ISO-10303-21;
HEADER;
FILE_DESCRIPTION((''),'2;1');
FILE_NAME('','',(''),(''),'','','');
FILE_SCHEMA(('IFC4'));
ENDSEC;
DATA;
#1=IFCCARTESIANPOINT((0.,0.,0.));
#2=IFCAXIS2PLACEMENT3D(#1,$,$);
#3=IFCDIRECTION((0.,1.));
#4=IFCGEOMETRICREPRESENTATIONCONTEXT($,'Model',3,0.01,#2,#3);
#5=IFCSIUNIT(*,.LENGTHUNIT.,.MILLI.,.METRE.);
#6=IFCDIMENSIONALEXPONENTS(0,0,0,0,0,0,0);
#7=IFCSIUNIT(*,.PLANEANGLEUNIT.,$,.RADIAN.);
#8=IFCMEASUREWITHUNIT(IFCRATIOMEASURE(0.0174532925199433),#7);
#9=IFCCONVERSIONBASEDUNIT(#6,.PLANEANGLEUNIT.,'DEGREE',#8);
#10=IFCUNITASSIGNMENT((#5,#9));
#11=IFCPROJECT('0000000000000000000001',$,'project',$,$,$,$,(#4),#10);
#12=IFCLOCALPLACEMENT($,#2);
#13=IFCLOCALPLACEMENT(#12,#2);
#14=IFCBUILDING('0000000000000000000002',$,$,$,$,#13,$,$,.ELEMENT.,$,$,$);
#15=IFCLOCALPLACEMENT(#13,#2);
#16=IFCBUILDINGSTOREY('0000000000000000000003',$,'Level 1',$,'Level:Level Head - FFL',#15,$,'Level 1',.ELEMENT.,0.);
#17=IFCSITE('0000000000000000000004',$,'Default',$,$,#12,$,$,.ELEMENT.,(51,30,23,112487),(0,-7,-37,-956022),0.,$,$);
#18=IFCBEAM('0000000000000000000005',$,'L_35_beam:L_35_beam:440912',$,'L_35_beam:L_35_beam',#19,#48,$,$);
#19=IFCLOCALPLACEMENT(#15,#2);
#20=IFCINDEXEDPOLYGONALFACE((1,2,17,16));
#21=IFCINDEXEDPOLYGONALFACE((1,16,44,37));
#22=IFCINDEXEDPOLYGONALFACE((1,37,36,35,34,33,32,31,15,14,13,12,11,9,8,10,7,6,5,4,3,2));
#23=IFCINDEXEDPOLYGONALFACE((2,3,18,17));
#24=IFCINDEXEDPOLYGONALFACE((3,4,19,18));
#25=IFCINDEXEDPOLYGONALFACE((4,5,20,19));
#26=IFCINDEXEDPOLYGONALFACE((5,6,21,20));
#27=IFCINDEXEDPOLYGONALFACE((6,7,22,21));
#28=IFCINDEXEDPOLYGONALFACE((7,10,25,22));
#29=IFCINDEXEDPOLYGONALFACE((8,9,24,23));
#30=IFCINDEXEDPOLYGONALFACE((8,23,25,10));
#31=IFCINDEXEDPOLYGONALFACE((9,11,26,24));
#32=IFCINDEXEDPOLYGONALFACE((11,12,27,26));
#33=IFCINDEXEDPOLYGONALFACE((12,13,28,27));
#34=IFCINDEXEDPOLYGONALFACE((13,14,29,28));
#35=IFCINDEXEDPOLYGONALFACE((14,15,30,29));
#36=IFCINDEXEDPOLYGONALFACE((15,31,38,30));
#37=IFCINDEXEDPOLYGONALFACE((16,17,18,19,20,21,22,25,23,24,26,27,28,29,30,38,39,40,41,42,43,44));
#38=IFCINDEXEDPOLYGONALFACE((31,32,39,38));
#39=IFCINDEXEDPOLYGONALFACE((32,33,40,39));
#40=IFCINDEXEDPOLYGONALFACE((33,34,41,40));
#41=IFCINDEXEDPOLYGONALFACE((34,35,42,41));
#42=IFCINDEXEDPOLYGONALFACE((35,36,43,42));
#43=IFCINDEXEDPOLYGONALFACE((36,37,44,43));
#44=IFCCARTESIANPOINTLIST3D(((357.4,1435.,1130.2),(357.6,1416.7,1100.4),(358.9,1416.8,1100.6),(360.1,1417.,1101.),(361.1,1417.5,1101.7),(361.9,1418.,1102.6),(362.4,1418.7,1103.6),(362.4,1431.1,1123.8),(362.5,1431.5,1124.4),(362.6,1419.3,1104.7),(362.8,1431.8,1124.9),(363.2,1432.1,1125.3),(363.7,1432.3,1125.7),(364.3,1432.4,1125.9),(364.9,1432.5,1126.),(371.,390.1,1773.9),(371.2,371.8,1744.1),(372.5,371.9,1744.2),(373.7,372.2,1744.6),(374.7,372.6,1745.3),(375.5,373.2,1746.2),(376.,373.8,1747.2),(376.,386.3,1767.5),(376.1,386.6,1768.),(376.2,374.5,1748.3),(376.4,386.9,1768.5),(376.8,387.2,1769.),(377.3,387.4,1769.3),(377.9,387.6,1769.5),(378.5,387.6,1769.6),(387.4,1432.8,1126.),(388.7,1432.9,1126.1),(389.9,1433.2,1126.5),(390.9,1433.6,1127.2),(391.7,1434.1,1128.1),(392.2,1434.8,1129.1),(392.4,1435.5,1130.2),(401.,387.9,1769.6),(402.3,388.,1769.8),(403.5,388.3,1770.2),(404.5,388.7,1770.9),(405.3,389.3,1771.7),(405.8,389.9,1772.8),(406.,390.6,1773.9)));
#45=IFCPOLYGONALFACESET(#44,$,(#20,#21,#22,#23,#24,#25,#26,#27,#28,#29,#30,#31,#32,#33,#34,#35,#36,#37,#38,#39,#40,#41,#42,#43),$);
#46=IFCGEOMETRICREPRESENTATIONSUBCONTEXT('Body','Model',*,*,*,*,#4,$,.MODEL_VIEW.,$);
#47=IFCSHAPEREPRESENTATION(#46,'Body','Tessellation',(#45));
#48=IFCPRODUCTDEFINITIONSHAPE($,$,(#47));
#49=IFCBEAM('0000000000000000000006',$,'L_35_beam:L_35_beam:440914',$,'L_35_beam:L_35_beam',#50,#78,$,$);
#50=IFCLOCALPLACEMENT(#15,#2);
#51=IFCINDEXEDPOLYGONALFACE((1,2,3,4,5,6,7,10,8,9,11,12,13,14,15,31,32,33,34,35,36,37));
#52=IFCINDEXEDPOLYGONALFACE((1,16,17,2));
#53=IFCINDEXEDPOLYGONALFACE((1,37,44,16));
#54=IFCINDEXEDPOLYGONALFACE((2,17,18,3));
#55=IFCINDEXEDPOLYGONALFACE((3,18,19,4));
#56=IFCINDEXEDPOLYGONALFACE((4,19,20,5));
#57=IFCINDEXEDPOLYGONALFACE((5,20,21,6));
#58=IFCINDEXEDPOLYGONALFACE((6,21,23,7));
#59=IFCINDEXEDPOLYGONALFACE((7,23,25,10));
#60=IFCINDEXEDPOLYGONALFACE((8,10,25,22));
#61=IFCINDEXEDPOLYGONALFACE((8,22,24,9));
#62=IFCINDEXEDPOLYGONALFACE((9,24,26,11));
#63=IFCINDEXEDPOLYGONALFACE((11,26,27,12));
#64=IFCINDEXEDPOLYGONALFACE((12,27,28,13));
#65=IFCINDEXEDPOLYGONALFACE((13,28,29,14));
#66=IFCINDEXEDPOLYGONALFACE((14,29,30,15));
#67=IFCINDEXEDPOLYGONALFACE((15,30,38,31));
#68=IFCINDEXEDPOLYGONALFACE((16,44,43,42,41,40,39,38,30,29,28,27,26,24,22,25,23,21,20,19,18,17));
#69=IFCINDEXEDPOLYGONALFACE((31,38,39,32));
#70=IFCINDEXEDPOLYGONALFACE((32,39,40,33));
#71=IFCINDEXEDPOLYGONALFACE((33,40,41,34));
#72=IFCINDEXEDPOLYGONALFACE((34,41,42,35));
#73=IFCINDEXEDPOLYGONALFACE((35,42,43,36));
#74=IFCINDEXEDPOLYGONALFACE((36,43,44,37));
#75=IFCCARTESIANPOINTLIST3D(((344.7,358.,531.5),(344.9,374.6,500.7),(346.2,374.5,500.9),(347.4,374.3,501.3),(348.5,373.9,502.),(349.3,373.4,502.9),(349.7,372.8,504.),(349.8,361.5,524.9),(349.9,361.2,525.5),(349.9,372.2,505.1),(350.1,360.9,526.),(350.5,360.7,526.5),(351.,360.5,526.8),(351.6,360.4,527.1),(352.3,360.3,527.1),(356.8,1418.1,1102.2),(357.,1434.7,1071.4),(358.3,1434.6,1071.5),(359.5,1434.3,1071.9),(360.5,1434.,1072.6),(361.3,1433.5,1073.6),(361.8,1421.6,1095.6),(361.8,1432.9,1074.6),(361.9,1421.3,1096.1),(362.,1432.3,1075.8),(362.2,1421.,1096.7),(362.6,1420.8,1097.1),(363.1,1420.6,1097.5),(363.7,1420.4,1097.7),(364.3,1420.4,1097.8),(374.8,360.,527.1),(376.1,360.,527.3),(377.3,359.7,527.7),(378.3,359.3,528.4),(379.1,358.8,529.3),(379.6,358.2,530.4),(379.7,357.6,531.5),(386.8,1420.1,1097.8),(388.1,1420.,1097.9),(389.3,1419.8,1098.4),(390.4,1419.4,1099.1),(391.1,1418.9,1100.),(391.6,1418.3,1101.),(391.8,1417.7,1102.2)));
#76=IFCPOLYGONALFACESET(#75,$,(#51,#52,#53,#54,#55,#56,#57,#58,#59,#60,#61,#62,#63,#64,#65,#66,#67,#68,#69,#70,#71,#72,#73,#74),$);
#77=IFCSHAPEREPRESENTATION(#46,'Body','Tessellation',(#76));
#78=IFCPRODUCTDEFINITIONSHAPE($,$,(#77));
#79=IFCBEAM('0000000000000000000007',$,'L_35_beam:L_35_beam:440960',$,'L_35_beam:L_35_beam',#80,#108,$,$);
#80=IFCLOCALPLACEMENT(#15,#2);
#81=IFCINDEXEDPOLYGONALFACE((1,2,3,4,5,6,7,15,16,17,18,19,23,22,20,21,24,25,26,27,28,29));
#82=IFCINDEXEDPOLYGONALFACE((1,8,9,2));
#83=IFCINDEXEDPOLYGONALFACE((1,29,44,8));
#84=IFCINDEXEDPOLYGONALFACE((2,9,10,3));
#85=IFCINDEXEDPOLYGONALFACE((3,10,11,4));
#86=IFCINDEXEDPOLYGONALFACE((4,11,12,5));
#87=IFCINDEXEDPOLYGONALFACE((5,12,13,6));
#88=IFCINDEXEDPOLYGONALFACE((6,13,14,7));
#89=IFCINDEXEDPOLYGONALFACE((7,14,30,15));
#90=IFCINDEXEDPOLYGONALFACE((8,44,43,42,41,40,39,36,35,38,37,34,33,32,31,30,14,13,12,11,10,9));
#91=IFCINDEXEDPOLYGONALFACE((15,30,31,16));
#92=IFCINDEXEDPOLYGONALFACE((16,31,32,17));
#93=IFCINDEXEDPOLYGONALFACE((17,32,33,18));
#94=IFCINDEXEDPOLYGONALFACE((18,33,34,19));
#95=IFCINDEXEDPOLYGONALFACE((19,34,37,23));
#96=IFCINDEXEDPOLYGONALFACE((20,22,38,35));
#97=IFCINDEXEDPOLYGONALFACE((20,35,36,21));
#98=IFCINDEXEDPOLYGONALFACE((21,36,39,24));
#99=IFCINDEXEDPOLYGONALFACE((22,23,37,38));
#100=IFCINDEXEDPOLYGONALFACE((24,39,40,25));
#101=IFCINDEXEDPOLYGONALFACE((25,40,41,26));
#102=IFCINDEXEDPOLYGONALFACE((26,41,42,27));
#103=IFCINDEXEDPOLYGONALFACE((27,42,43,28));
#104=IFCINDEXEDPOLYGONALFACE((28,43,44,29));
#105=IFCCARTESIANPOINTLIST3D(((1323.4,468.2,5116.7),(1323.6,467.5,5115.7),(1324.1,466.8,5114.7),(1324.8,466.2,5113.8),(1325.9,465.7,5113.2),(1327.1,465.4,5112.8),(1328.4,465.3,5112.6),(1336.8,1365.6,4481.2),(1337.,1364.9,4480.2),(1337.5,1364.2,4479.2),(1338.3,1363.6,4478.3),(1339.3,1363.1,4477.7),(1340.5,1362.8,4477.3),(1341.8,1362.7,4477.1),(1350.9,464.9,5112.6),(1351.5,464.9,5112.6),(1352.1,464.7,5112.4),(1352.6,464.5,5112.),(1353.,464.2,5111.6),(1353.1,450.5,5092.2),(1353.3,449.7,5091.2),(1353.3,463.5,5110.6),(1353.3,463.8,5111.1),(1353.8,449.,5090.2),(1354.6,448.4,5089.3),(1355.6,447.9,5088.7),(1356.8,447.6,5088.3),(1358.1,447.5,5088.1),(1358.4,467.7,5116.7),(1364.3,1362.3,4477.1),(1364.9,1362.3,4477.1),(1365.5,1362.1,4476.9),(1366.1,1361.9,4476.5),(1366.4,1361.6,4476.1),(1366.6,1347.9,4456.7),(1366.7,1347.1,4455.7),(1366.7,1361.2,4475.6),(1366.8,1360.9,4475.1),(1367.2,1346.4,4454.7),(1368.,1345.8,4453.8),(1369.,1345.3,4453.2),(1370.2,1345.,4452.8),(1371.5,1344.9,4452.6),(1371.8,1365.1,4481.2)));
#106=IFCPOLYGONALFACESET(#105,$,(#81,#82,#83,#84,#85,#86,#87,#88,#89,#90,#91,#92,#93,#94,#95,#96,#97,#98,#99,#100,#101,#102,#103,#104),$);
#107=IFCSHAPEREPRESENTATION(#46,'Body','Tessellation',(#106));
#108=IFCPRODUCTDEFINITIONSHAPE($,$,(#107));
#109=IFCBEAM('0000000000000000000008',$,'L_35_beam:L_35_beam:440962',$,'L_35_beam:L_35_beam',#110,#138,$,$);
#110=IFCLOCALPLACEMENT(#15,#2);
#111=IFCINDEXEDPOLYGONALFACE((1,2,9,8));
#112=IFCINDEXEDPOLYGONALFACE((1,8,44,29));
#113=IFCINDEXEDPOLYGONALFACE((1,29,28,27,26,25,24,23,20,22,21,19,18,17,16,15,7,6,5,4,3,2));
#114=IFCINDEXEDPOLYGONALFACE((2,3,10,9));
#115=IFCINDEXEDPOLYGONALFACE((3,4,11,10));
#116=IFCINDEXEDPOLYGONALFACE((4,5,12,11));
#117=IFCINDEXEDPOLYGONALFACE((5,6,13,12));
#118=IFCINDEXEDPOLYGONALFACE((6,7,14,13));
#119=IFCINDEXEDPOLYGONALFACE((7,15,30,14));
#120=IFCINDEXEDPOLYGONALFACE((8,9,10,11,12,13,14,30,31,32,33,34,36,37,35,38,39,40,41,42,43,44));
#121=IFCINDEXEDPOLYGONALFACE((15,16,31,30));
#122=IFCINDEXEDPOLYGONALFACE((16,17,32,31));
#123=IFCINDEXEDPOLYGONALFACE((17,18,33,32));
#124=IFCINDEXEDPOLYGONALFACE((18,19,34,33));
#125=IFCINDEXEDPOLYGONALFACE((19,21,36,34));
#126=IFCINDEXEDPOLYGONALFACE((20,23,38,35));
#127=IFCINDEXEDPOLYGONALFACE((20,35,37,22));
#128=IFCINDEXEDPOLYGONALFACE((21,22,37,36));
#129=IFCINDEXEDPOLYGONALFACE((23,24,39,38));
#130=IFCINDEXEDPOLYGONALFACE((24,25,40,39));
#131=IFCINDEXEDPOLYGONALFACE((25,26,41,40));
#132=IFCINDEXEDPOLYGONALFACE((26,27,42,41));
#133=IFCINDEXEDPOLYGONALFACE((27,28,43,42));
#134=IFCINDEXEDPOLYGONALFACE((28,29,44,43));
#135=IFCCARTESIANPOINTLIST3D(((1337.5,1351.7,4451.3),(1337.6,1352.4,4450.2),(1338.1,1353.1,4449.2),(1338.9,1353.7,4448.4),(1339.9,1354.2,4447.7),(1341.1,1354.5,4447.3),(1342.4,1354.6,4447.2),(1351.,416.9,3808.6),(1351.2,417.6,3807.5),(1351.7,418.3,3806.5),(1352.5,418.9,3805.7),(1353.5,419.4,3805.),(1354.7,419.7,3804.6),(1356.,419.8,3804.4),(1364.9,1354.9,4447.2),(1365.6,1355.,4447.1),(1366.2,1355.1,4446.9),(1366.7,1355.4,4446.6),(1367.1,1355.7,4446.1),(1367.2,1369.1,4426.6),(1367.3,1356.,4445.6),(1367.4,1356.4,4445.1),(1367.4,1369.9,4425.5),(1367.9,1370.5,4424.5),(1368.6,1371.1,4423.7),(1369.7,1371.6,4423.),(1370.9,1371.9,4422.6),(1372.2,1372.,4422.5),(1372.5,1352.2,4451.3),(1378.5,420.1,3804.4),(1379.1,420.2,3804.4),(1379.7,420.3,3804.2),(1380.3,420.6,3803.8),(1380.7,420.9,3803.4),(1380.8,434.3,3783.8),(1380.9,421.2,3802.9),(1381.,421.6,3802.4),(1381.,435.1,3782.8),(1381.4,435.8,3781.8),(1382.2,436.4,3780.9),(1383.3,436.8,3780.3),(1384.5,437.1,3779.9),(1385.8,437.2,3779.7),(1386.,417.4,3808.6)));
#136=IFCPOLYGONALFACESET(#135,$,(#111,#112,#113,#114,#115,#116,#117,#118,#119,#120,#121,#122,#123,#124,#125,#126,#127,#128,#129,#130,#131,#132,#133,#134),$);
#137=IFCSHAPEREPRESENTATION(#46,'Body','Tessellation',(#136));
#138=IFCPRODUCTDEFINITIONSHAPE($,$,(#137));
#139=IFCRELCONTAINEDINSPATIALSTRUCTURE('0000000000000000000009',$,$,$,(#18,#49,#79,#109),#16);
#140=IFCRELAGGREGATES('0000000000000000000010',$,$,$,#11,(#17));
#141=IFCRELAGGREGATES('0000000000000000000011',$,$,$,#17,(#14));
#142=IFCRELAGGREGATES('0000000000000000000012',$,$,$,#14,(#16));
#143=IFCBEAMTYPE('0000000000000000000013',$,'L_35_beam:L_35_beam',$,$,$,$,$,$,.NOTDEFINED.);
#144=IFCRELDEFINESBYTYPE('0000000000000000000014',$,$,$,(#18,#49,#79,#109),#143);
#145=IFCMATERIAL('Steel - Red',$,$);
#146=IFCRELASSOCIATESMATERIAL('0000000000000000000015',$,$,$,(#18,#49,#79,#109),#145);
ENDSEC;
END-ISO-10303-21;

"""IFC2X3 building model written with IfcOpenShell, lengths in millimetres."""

from ifc_helpers import new_model, entity, si_unit, converted_unit, direction, frame, frame_2d, origin, place, context, subcontext, project, spatial, polyline, circle_curve, parameter, trimmed, segment, composite_curve, outline, extrude, material, type_object, element, save


model = new_model("IFC2X3")

# Units and contexts
model_context = context("Model", 3, precision=0.01, world=origin(), true_north=direction((0.0, 1.0)))
body_context = subcontext(model_context, "Body", "Model", "MODEL_VIEW")
ifc_project = project(units=[si_unit("LENGTHUNIT", "METRE", prefix="MILLI"), converted_unit("PLANEANGLEUNIT", "DEGREE", entity("IfcRatioMeasure", 0.0174532925199433), si_unit("PLANEANGLEUNIT", "RADIAN"), dimensions=[0, 0, 0, 0, 0, 0, 0])], contexts=[model_context])

# Site, building, storey
site_placement = place(None, origin())
site = spatial("IfcSite", under=ifc_project, at=site_placement, Name="Default", CompositionType="ELEMENT", RefLatitude=(51, 30, 23, 112487), RefLongitude=(0, -7, -37, -956022), RefElevation=0.0)
building_placement = place(site_placement, origin())
building = spatial("IfcBuilding", under=site, at=building_placement, CompositionType="ELEMENT")
storey_placement = place(building_placement, origin())
storey = spatial("IfcBuildingStorey", under=building, at=storey_placement, Name="Level 1", ObjectType="Level:Level Head - FFL", LongName="Level 1", CompositionType="ELEMENT", Elevation=0.0)

# Beams
ifc_material_1 = material(Name="Steel - Red")
beam_type = type_object("IfcBeamType", Name="L_35_beam:L_35_beam", PredefinedType="NOTDEFINED")
beam_1_placement = place(storey_placement, frame((363.3, 363.3, 1769.8), z_axis=(-0.006825, 0.524399, 0.851445), x_axis=(-0.011081, 0.851373, -0.524443)))
element("IfcBeam", 1, at=beam_1_placement, inside=storey, type_object=beam_type, material=ifc_material_1, Name="L_35_beam:L_35_beam:440912", ObjectType="L_35_beam:L_35_beam", context=body_context, shape_type="SweptSolid", body=[
    extrude(outline(composite_curve([segment(polyline([(-23.2, -11.8), (11.8, -11.8)]), True, "CONTINUOUS"), segment(polyline([(11.8, -11.8), (11.8, 23.2)]), True, "CONTINUOUS"), segment(trimmed(circle_curve(frame_2d((11.8, 18.2), x_axis=(0.0, 1.0)), 5.0), [parameter(0.0)], [parameter(90.0)], True, "PARAMETER"), True, "CONTINUOUS"), segment(polyline([(6.8, 18.2), (6.8, -4.3)]), True, "CONTINUOUS"), segment(trimmed(circle_curve(frame_2d((4.3, -4.3), x_axis=(1.0, 0.0)), 2.5), [parameter(270.0)], [parameter(0.0)], True, "PARAMETER"), False, "CONTINUOUS"), segment(polyline([(4.3, -6.8), (-18.2, -6.8)]), True, "CONTINUOUS"), segment(trimmed(circle_curve(frame_2d((-18.2, -11.8), x_axis=(0.0, 1.0)), 5.0), [parameter(0.0)], [parameter(90.0)], True, "PARAMETER"), True, "CONTINUOUS")], self_intersect=False)), frame((20.6, -19.8, 5.7), z_axis=(1.0, 0.0, 0.0), x_axis=(0.0, 0.0, 1.0)), (0.0, 0.0, 1.0), 1227.3),
])
beam_2_placement = place(storey_placement, frame((336.5, 336.5, 500.0), z_axis=(-0.005391, -0.473926, 0.880548), x_axis=(0.010015, 0.880491, 0.473956)))
element("IfcBeam", 2, at=beam_2_placement, inside=storey, type_object=beam_type, material=ifc_material_1, Name="L_35_beam:L_35_beam:440914", ObjectType="L_35_beam:L_35_beam", context=body_context, shape_type="SweptSolid", body=[
    extrude(outline(composite_curve([segment(polyline([(-23.2, -11.8), (11.8, -11.8)]), True, "CONTINUOUS"), segment(polyline([(11.8, -11.8), (11.8, 23.2)]), True, "CONTINUOUS"), segment(trimmed(circle_curve(frame_2d((11.8, 18.2), x_axis=(0.0, 1.0)), 5.0), [parameter(0.0)], [parameter(90.0)], True, "PARAMETER"), True, "CONTINUOUS"), segment(polyline([(6.8, 18.2), (6.8, -4.3)]), True, "CONTINUOUS"), segment(trimmed(circle_curve(frame_2d((4.3, -4.3), x_axis=(1.0, 0.0)), 2.5), [parameter(270.0)], [parameter(0.0)], True, "PARAMETER"), False, "CONTINUOUS"), segment(polyline([(4.3, -6.8), (-18.2, -6.8)]), True, "CONTINUOUS"), segment(trimmed(circle_curve(frame_2d((-18.2, -11.8), x_axis=(0.0, 1.0)), 5.0), [parameter(0.0)], [parameter(90.0)], True, "PARAMETER"), True, "CONTINUOUS")], self_intersect=False)), frame((34.0, -19.8, 5.7), z_axis=(1.0, 0.0, 0.0), x_axis=(0.0, 0.0, 1.0)), (0.0, 0.0, 1.0), 1204.0),
])
beam_3_placement = place(storey_placement, frame((1380.1, 1380.0, 4449.1), z_axis=(0.008646, 0.577808, 0.816127), x_axis=(-0.01221, -0.816035, 0.577873)))
element("IfcBeam", 3, at=beam_3_placement, inside=storey, type_object=beam_type, material=ifc_material_1, Name="L_35_beam:L_35_beam:440960", ObjectType="L_35_beam:L_35_beam", context=body_context, shape_type="SweptSolid", body=[
    extrude(outline(composite_curve([segment(polyline([(-23.2, -11.8), (11.8, -11.8)]), True, "CONTINUOUS"), segment(polyline([(11.8, -11.8), (11.8, 23.2)]), True, "CONTINUOUS"), segment(trimmed(circle_curve(frame_2d((11.8, 18.2), x_axis=(0.0, 1.0)), 5.0), [parameter(0.0)], [parameter(90.0)], True, "PARAMETER"), True, "CONTINUOUS"), segment(polyline([(6.8, 18.2), (6.8, -4.3)]), True, "CONTINUOUS"), segment(trimmed(circle_curve(frame_2d((4.3, -4.3), x_axis=(1.0, 0.0)), 2.5), [parameter(270.0)], [parameter(0.0)], True, "PARAMETER"), False, "CONTINUOUS"), segment(polyline([(4.3, -6.8), (-18.2, -6.8)]), True, "CONTINUOUS"), segment(trimmed(circle_curve(frame_2d((-18.2, -11.8), x_axis=(0.0, 1.0)), 5.0), [parameter(0.0)], [parameter(90.0)], True, "PARAMETER"), True, "CONTINUOUS")], self_intersect=False)), frame((30.8, -19.8, 5.7), z_axis=(1.0, 0.0, 0.0), x_axis=(0.0, 0.0, 1.0)), (0.0, 0.0, 1.0), 1099.7),
])
beam_4_placement = place(storey_placement, frame((1380.1, 1380.0, 4449.1), z_axis=(0.00823, -0.566466, 0.824044), x_axis=(0.01197, -0.823957, -0.566525)))
element("IfcBeam", 4, at=beam_4_placement, inside=storey, type_object=beam_type, material=ifc_material_1, Name="L_35_beam:L_35_beam:440962", ObjectType="L_35_beam:L_35_beam", context=body_context, shape_type="SweptSolid", body=[
    extrude(outline(composite_curve([segment(polyline([(-23.2, -11.8), (11.8, -11.8)]), True, "CONTINUOUS"), segment(polyline([(11.8, -11.8), (11.8, 23.2)]), True, "CONTINUOUS"), segment(trimmed(circle_curve(frame_2d((11.8, 18.2), x_axis=(0.0, 1.0)), 5.0), [parameter(0.0)], [parameter(90.0)], True, "PARAMETER"), True, "CONTINUOUS"), segment(polyline([(6.8, 18.2), (6.8, -4.3)]), True, "CONTINUOUS"), segment(trimmed(circle_curve(frame_2d((4.3, -4.3), x_axis=(1.0, 0.0)), 2.5), [parameter(270.0)], [parameter(0.0)], True, "PARAMETER"), False, "CONTINUOUS"), segment(polyline([(4.3, -6.8), (-18.2, -6.8)]), True, "CONTINUOUS"), segment(trimmed(circle_curve(frame_2d((-18.2, -11.8), x_axis=(0.0, 1.0)), 5.0), [parameter(0.0)], [parameter(90.0)], True, "PARAMETER"), True, "CONTINUOUS")], self_intersect=False)), frame((21.6, -19.8, 5.7), z_axis=(1.0, 0.0, 0.0), x_axis=(0.0, 0.0, 1.0)), (0.0, 0.0, 1.0), 1134.5),
])

save(model, "model.ifc")
